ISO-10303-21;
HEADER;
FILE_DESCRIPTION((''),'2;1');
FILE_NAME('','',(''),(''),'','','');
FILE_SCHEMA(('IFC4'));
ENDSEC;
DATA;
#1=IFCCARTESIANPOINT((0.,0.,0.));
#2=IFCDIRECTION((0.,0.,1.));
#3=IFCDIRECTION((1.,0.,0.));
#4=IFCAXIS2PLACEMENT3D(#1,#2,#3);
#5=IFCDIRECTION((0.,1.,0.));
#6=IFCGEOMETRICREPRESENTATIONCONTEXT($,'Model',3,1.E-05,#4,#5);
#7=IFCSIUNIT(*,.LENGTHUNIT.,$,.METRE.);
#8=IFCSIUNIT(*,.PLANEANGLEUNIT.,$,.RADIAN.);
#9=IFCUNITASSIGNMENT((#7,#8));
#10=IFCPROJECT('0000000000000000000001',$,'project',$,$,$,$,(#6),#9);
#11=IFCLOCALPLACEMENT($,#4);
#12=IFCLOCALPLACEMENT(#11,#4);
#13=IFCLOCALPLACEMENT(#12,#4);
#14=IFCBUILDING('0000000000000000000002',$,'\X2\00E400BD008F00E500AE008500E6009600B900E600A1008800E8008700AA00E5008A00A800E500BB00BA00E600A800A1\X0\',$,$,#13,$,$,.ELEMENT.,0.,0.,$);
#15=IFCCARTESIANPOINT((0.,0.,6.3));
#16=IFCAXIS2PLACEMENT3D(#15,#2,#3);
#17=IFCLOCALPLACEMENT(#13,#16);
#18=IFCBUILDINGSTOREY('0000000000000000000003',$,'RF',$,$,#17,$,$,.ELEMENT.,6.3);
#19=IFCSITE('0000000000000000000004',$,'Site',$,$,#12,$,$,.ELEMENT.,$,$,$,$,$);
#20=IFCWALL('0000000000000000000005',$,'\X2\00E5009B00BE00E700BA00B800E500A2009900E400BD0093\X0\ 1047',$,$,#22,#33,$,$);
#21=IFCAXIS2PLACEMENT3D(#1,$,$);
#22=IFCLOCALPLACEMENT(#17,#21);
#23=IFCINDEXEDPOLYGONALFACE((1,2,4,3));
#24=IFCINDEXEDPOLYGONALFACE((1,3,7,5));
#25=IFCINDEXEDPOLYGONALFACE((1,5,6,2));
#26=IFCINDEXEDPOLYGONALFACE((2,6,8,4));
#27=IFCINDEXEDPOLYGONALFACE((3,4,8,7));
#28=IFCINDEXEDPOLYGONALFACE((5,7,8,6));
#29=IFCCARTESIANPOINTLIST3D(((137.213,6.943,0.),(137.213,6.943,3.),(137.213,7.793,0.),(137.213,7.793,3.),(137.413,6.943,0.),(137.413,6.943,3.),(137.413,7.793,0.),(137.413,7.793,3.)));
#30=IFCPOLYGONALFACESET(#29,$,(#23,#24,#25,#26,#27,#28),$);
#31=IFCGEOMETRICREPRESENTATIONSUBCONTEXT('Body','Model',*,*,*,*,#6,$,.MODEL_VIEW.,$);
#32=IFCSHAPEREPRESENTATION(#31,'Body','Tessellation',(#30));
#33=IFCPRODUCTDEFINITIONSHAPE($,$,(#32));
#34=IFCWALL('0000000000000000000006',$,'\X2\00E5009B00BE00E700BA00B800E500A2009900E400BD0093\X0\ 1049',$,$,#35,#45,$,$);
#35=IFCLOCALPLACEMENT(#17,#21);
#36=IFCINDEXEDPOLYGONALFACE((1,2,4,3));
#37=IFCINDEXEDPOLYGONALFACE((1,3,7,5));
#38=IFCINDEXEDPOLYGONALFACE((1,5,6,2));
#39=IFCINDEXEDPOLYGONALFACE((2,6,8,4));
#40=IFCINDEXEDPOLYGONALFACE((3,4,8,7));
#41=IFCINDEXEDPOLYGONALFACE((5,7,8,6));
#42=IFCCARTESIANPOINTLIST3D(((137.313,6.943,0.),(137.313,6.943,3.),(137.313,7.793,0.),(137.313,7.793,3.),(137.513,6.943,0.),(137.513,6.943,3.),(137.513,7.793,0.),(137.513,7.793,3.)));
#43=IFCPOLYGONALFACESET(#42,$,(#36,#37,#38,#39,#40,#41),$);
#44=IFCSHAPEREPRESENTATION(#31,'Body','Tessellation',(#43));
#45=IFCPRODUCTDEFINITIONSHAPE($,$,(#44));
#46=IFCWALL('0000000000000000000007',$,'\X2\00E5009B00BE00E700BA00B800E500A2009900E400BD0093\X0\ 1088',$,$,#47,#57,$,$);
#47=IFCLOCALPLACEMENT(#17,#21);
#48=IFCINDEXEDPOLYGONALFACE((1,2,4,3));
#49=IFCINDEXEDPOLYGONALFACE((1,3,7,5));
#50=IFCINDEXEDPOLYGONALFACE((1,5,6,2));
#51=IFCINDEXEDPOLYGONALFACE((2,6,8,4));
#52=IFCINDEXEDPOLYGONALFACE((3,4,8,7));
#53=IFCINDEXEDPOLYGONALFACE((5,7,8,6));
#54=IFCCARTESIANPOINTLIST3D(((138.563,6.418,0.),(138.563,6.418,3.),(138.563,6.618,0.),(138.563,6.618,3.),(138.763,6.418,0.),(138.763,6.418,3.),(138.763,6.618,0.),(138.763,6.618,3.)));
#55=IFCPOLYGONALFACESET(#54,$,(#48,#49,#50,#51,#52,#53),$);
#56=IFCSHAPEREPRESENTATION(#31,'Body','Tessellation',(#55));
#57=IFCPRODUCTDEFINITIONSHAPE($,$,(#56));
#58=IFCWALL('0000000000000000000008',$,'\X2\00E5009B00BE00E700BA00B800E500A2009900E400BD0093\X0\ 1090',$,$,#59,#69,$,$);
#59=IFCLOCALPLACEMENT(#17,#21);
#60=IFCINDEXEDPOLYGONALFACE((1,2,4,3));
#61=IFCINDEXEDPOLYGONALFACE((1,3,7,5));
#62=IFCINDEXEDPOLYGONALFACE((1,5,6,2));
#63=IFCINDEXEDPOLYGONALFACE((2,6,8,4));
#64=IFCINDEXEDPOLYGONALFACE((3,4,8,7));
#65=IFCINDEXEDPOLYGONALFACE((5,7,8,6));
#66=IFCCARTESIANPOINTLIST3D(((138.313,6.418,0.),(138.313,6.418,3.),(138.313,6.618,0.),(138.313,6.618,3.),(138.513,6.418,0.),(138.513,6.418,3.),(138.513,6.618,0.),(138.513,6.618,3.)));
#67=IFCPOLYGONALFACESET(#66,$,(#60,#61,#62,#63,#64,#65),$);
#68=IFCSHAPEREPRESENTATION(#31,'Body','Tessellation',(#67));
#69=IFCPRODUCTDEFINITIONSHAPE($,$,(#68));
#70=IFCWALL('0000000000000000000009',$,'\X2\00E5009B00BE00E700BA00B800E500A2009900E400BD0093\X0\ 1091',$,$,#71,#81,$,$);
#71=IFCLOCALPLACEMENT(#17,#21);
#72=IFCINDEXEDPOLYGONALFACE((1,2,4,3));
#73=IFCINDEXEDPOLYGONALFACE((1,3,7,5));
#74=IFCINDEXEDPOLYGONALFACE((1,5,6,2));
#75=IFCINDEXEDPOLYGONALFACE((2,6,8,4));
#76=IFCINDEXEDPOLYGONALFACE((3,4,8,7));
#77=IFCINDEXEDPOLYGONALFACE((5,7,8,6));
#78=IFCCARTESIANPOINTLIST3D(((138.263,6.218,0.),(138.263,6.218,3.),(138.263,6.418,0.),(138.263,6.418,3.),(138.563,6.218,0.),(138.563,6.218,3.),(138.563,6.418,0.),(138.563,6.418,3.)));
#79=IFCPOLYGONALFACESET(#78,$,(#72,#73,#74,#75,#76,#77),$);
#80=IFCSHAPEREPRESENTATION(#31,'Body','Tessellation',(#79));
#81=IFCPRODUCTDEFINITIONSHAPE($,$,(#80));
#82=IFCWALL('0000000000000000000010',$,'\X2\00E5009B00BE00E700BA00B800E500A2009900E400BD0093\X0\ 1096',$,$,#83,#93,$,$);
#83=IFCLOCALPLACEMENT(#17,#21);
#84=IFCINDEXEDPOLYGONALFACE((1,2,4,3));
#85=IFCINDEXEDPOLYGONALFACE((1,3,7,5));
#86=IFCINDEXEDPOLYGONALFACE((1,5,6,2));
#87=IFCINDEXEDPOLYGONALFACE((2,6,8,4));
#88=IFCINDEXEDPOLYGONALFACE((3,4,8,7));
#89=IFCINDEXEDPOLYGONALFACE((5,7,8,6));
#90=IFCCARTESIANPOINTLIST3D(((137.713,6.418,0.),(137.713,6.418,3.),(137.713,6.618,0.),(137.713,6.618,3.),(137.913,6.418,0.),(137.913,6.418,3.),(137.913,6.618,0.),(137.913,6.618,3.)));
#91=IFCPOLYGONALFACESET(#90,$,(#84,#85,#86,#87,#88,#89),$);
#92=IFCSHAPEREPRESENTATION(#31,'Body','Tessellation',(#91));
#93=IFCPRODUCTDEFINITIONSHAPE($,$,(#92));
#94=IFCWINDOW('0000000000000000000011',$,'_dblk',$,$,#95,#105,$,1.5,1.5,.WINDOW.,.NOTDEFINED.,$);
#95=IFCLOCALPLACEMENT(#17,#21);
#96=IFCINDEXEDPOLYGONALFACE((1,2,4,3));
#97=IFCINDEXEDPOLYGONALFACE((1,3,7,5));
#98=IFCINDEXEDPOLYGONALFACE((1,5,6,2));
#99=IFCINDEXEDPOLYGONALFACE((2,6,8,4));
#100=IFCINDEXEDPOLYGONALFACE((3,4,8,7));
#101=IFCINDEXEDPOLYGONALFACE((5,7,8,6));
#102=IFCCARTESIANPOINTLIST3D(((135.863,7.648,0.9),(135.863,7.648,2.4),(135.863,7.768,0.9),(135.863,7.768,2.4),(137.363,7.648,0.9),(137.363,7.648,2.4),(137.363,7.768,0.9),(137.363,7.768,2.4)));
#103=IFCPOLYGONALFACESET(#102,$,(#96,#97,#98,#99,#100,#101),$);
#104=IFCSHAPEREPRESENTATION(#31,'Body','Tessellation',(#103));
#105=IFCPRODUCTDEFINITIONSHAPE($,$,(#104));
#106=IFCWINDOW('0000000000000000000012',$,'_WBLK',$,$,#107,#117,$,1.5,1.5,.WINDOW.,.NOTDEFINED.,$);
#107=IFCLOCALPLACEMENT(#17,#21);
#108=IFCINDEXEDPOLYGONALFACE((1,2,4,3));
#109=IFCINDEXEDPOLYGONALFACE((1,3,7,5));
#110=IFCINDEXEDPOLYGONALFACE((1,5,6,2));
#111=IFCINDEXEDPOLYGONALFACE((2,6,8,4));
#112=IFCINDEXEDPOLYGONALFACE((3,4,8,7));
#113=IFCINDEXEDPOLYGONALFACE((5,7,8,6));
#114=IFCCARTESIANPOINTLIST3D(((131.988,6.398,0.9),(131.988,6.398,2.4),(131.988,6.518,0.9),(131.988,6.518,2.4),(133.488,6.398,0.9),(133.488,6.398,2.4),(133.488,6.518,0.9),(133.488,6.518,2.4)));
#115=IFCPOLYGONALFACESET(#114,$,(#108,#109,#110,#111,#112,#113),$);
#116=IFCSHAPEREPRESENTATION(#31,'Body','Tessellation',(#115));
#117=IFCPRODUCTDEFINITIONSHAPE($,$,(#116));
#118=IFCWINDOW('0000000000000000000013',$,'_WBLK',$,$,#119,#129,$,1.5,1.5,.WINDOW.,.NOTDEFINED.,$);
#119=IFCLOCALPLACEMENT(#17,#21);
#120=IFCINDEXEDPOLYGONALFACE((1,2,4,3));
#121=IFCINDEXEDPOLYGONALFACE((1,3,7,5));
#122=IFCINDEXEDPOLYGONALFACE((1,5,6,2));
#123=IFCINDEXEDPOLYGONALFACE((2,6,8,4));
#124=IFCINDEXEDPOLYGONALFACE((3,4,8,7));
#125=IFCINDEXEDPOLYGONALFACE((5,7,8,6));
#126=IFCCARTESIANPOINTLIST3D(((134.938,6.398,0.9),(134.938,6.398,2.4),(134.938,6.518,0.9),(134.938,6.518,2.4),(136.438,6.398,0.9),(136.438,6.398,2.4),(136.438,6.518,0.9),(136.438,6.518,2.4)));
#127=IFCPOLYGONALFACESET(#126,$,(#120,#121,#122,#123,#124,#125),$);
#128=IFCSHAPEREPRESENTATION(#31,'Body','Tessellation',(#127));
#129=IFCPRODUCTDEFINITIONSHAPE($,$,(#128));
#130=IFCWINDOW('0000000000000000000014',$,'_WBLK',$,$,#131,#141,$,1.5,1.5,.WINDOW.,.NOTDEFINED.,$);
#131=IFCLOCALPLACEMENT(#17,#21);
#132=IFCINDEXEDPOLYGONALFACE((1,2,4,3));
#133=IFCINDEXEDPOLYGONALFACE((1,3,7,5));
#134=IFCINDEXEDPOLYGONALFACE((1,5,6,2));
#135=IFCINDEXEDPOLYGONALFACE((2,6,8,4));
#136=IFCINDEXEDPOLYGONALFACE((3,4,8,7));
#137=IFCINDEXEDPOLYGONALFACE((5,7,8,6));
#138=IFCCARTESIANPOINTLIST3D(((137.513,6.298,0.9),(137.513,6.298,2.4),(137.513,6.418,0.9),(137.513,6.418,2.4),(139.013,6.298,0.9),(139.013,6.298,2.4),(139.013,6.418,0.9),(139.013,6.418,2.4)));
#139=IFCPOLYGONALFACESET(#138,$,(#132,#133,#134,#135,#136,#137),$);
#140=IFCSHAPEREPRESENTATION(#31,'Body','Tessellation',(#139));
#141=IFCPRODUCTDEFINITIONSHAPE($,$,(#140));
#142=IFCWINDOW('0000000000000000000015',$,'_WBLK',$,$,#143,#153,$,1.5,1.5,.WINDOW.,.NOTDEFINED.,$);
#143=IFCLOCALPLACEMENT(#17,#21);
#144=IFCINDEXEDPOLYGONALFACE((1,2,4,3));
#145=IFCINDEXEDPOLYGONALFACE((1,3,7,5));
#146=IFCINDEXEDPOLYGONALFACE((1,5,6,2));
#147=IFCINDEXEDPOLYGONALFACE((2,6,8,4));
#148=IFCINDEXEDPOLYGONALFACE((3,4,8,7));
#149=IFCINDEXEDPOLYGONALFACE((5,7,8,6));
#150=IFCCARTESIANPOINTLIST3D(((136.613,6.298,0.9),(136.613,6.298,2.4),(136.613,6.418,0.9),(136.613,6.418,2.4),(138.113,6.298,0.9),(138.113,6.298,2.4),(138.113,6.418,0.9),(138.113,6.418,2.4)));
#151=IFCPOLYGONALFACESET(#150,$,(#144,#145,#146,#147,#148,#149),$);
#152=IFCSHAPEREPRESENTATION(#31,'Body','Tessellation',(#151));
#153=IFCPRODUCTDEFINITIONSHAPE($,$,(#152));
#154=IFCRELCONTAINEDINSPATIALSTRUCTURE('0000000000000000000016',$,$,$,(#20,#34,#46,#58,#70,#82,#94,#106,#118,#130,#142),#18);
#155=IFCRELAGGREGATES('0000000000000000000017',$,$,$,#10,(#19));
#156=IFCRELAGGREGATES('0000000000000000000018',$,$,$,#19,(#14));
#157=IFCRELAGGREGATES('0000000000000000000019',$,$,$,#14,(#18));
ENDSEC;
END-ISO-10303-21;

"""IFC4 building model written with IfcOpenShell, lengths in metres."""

from ifc_helpers import new_model, si_unit, direction, frame, frame_2d, origin_with_axes, place, context, subcontext, project, spatial, rectangle, extrude, element, save


model = new_model("IFC4")

# Units and contexts
model_context = context("Model", 3, precision=1e-05, world=origin_with_axes(), true_north=direction((0.0, 1.0, 0.0)))
body_context = subcontext(model_context, "Body", "Model", "MODEL_VIEW")
ifc_project = project(units=[si_unit("LENGTHUNIT", "METRE"), si_unit("PLANEANGLEUNIT", "RADIAN")], contexts=[model_context])

# Site, building, storey
placement = place(None, origin_with_axes())
site_placement = place(placement, origin_with_axes())
site = spatial("IfcSite", under=ifc_project, at=site_placement, Name="Site", CompositionType="ELEMENT")
building_placement = place(site_placement, origin_with_axes())
building = spatial("IfcBuilding", under=site, at=building_placement, Name="ä½\u008få®\u0085æ\u0096¹æ¡\u0088è\u0087ªå\u008a¨å»ºæ¨¡", CompositionType="ELEMENT", ElevationOfRefHeight=0.0, ElevationOfTerrain=0.0)
storey_placement = place(building_placement, frame((0.0, 0.0, 6.3), z_axis=(0.0, 0.0, 1.0), x_axis=(1.0, 0.0, 0.0)))
storey = spatial("IfcBuildingStorey", under=building, at=storey_placement, Name="RF", CompositionType="ELEMENT", Elevation=6.3)

# Walls
for number, where, z_axis, x_axis, name in (
    (1, (137.313, 7.368, 0.0), (0.0, 0.0, 1.0), (0.0, -1.0, 0.0), "å\u009b¾çº¸å¢\u0099ä½\u0093 1047"),
    (2, (137.413, 7.368, 0.0), (0.0, 0.0, 1.0), (0.0, -1.0, 0.0), "å\u009b¾çº¸å¢\u0099ä½\u0093 1049"),
):
    element("IfcWall", number, at=place(storey_placement, frame(where, z_axis=z_axis, x_axis=x_axis)), inside=storey, Name=name, context=body_context, shape_type="SweptSolid", body=[
        extrude(rectangle(XDim=0.85, YDim=0.2, at=frame_2d((0.0, 0.0), x_axis=(1.0, 0.0, 0.0))), frame((0.0, 0.0, 0.0), z_axis=(0.0, 0.0, 1.0)), (0.0, 0.0, 1.0), 3.0),
    ])
for number, where, z_axis, x_axis, name in (
    (3, (138.663, 6.518, 0.0), (0.0, 0.0, 1.0), (1.0, 0.0, 0.0), "å\u009b¾çº¸å¢\u0099ä½\u0093 1088"),
    (4, (138.413, 6.518, 0.0), (0.0, 0.0, 1.0), (1.0, 0.0, 0.0), "å\u009b¾çº¸å¢\u0099ä½\u0093 1090"),
):
    element("IfcWall", number, at=place(storey_placement, frame(where, z_axis=z_axis, x_axis=x_axis)), inside=storey, Name=name, context=body_context, shape_type="SweptSolid", body=[
        extrude(rectangle(XDim=0.2, YDim=0.2, at=frame_2d((0.0, 0.0), x_axis=(1.0, 0.0, 0.0))), frame((0.0, 0.0, 0.0), z_axis=(0.0, 0.0, 1.0)), (0.0, 0.0, 1.0), 3.0),
    ])
wall_1_placement = place(storey_placement, frame((138.413, 6.318, 0.0), z_axis=(0.0, 0.0, 1.0), x_axis=(1.0, 0.0, 0.0)))
element("IfcWall", 5, at=wall_1_placement, inside=storey, Name="å\u009b¾çº¸å¢\u0099ä½\u0093 1091", context=body_context, shape_type="SweptSolid", body=[
    extrude(rectangle(XDim=0.3, YDim=0.2, at=frame_2d((0.0, 0.0), x_axis=(1.0, 0.0, 0.0))), frame((0.0, 0.0, 0.0), z_axis=(0.0, 0.0, 1.0)), (0.0, 0.0, 1.0), 3.0),
])
for number, where, z_axis, x_axis, name in (
    (6, (137.813, 6.518, 0.0), (0.0, 0.0, 1.0), (0.0, -1.0, 0.0), "å\u009b¾çº¸å¢\u0099ä½\u0093 1096"),
):
    element("IfcWall", number, at=place(storey_placement, frame(where, z_axis=z_axis, x_axis=x_axis)), inside=storey, Name=name, context=body_context, shape_type="SweptSolid", body=[
        extrude(rectangle(XDim=0.2, YDim=0.2, at=frame_2d((0.0, 0.0), x_axis=(1.0, 0.0, 0.0))), frame((0.0, 0.0, 0.0), z_axis=(0.0, 0.0, 1.0)), (0.0, 0.0, 1.0), 3.0),
    ])

# Windows
for number, where, z_axis, x_axis, name in (
    (7, (136.613, 7.708, 0.9), (0.0, 0.0, 1.0), (1.0, 0.0, 0.0), "_dblk"),
    (8, (132.738, 6.458, 0.9), (0.0, 0.0, 1.0), (1.0, 0.0, 0.0), "_WBLK"),
    (9, (135.688, 6.458, 0.9), (0.0, 0.0, 1.0), (1.0, 0.0, 0.0), "_WBLK"),
    (10, (138.263, 6.358, 0.9), (0.0, 0.0, 1.0), (1.0, 0.0, 0.0), "_WBLK"),
    (11, (137.363, 6.358, 0.9), (0.0, 0.0, 1.0), (1.0, 0.0, 0.0), "_WBLK"),
):
    element("IfcWindow", number, at=place(storey_placement, frame(where, z_axis=z_axis, x_axis=x_axis)), inside=storey, Name=name, OverallHeight=1.5, OverallWidth=1.5, PartitioningType="NOTDEFINED", PredefinedType="WINDOW", context=body_context, shape_type="SweptSolid", body=[
        extrude(rectangle(XDim=1.5, YDim=0.12, at=frame_2d((0.0, 0.0), x_axis=(1.0, 0.0, 0.0))), frame((0.0, 0.0, 0.0), z_axis=(0.0, 0.0, 1.0)), (0.0, 0.0, 1.0), 1.5),
    ])

save(model, "model.ifc")
